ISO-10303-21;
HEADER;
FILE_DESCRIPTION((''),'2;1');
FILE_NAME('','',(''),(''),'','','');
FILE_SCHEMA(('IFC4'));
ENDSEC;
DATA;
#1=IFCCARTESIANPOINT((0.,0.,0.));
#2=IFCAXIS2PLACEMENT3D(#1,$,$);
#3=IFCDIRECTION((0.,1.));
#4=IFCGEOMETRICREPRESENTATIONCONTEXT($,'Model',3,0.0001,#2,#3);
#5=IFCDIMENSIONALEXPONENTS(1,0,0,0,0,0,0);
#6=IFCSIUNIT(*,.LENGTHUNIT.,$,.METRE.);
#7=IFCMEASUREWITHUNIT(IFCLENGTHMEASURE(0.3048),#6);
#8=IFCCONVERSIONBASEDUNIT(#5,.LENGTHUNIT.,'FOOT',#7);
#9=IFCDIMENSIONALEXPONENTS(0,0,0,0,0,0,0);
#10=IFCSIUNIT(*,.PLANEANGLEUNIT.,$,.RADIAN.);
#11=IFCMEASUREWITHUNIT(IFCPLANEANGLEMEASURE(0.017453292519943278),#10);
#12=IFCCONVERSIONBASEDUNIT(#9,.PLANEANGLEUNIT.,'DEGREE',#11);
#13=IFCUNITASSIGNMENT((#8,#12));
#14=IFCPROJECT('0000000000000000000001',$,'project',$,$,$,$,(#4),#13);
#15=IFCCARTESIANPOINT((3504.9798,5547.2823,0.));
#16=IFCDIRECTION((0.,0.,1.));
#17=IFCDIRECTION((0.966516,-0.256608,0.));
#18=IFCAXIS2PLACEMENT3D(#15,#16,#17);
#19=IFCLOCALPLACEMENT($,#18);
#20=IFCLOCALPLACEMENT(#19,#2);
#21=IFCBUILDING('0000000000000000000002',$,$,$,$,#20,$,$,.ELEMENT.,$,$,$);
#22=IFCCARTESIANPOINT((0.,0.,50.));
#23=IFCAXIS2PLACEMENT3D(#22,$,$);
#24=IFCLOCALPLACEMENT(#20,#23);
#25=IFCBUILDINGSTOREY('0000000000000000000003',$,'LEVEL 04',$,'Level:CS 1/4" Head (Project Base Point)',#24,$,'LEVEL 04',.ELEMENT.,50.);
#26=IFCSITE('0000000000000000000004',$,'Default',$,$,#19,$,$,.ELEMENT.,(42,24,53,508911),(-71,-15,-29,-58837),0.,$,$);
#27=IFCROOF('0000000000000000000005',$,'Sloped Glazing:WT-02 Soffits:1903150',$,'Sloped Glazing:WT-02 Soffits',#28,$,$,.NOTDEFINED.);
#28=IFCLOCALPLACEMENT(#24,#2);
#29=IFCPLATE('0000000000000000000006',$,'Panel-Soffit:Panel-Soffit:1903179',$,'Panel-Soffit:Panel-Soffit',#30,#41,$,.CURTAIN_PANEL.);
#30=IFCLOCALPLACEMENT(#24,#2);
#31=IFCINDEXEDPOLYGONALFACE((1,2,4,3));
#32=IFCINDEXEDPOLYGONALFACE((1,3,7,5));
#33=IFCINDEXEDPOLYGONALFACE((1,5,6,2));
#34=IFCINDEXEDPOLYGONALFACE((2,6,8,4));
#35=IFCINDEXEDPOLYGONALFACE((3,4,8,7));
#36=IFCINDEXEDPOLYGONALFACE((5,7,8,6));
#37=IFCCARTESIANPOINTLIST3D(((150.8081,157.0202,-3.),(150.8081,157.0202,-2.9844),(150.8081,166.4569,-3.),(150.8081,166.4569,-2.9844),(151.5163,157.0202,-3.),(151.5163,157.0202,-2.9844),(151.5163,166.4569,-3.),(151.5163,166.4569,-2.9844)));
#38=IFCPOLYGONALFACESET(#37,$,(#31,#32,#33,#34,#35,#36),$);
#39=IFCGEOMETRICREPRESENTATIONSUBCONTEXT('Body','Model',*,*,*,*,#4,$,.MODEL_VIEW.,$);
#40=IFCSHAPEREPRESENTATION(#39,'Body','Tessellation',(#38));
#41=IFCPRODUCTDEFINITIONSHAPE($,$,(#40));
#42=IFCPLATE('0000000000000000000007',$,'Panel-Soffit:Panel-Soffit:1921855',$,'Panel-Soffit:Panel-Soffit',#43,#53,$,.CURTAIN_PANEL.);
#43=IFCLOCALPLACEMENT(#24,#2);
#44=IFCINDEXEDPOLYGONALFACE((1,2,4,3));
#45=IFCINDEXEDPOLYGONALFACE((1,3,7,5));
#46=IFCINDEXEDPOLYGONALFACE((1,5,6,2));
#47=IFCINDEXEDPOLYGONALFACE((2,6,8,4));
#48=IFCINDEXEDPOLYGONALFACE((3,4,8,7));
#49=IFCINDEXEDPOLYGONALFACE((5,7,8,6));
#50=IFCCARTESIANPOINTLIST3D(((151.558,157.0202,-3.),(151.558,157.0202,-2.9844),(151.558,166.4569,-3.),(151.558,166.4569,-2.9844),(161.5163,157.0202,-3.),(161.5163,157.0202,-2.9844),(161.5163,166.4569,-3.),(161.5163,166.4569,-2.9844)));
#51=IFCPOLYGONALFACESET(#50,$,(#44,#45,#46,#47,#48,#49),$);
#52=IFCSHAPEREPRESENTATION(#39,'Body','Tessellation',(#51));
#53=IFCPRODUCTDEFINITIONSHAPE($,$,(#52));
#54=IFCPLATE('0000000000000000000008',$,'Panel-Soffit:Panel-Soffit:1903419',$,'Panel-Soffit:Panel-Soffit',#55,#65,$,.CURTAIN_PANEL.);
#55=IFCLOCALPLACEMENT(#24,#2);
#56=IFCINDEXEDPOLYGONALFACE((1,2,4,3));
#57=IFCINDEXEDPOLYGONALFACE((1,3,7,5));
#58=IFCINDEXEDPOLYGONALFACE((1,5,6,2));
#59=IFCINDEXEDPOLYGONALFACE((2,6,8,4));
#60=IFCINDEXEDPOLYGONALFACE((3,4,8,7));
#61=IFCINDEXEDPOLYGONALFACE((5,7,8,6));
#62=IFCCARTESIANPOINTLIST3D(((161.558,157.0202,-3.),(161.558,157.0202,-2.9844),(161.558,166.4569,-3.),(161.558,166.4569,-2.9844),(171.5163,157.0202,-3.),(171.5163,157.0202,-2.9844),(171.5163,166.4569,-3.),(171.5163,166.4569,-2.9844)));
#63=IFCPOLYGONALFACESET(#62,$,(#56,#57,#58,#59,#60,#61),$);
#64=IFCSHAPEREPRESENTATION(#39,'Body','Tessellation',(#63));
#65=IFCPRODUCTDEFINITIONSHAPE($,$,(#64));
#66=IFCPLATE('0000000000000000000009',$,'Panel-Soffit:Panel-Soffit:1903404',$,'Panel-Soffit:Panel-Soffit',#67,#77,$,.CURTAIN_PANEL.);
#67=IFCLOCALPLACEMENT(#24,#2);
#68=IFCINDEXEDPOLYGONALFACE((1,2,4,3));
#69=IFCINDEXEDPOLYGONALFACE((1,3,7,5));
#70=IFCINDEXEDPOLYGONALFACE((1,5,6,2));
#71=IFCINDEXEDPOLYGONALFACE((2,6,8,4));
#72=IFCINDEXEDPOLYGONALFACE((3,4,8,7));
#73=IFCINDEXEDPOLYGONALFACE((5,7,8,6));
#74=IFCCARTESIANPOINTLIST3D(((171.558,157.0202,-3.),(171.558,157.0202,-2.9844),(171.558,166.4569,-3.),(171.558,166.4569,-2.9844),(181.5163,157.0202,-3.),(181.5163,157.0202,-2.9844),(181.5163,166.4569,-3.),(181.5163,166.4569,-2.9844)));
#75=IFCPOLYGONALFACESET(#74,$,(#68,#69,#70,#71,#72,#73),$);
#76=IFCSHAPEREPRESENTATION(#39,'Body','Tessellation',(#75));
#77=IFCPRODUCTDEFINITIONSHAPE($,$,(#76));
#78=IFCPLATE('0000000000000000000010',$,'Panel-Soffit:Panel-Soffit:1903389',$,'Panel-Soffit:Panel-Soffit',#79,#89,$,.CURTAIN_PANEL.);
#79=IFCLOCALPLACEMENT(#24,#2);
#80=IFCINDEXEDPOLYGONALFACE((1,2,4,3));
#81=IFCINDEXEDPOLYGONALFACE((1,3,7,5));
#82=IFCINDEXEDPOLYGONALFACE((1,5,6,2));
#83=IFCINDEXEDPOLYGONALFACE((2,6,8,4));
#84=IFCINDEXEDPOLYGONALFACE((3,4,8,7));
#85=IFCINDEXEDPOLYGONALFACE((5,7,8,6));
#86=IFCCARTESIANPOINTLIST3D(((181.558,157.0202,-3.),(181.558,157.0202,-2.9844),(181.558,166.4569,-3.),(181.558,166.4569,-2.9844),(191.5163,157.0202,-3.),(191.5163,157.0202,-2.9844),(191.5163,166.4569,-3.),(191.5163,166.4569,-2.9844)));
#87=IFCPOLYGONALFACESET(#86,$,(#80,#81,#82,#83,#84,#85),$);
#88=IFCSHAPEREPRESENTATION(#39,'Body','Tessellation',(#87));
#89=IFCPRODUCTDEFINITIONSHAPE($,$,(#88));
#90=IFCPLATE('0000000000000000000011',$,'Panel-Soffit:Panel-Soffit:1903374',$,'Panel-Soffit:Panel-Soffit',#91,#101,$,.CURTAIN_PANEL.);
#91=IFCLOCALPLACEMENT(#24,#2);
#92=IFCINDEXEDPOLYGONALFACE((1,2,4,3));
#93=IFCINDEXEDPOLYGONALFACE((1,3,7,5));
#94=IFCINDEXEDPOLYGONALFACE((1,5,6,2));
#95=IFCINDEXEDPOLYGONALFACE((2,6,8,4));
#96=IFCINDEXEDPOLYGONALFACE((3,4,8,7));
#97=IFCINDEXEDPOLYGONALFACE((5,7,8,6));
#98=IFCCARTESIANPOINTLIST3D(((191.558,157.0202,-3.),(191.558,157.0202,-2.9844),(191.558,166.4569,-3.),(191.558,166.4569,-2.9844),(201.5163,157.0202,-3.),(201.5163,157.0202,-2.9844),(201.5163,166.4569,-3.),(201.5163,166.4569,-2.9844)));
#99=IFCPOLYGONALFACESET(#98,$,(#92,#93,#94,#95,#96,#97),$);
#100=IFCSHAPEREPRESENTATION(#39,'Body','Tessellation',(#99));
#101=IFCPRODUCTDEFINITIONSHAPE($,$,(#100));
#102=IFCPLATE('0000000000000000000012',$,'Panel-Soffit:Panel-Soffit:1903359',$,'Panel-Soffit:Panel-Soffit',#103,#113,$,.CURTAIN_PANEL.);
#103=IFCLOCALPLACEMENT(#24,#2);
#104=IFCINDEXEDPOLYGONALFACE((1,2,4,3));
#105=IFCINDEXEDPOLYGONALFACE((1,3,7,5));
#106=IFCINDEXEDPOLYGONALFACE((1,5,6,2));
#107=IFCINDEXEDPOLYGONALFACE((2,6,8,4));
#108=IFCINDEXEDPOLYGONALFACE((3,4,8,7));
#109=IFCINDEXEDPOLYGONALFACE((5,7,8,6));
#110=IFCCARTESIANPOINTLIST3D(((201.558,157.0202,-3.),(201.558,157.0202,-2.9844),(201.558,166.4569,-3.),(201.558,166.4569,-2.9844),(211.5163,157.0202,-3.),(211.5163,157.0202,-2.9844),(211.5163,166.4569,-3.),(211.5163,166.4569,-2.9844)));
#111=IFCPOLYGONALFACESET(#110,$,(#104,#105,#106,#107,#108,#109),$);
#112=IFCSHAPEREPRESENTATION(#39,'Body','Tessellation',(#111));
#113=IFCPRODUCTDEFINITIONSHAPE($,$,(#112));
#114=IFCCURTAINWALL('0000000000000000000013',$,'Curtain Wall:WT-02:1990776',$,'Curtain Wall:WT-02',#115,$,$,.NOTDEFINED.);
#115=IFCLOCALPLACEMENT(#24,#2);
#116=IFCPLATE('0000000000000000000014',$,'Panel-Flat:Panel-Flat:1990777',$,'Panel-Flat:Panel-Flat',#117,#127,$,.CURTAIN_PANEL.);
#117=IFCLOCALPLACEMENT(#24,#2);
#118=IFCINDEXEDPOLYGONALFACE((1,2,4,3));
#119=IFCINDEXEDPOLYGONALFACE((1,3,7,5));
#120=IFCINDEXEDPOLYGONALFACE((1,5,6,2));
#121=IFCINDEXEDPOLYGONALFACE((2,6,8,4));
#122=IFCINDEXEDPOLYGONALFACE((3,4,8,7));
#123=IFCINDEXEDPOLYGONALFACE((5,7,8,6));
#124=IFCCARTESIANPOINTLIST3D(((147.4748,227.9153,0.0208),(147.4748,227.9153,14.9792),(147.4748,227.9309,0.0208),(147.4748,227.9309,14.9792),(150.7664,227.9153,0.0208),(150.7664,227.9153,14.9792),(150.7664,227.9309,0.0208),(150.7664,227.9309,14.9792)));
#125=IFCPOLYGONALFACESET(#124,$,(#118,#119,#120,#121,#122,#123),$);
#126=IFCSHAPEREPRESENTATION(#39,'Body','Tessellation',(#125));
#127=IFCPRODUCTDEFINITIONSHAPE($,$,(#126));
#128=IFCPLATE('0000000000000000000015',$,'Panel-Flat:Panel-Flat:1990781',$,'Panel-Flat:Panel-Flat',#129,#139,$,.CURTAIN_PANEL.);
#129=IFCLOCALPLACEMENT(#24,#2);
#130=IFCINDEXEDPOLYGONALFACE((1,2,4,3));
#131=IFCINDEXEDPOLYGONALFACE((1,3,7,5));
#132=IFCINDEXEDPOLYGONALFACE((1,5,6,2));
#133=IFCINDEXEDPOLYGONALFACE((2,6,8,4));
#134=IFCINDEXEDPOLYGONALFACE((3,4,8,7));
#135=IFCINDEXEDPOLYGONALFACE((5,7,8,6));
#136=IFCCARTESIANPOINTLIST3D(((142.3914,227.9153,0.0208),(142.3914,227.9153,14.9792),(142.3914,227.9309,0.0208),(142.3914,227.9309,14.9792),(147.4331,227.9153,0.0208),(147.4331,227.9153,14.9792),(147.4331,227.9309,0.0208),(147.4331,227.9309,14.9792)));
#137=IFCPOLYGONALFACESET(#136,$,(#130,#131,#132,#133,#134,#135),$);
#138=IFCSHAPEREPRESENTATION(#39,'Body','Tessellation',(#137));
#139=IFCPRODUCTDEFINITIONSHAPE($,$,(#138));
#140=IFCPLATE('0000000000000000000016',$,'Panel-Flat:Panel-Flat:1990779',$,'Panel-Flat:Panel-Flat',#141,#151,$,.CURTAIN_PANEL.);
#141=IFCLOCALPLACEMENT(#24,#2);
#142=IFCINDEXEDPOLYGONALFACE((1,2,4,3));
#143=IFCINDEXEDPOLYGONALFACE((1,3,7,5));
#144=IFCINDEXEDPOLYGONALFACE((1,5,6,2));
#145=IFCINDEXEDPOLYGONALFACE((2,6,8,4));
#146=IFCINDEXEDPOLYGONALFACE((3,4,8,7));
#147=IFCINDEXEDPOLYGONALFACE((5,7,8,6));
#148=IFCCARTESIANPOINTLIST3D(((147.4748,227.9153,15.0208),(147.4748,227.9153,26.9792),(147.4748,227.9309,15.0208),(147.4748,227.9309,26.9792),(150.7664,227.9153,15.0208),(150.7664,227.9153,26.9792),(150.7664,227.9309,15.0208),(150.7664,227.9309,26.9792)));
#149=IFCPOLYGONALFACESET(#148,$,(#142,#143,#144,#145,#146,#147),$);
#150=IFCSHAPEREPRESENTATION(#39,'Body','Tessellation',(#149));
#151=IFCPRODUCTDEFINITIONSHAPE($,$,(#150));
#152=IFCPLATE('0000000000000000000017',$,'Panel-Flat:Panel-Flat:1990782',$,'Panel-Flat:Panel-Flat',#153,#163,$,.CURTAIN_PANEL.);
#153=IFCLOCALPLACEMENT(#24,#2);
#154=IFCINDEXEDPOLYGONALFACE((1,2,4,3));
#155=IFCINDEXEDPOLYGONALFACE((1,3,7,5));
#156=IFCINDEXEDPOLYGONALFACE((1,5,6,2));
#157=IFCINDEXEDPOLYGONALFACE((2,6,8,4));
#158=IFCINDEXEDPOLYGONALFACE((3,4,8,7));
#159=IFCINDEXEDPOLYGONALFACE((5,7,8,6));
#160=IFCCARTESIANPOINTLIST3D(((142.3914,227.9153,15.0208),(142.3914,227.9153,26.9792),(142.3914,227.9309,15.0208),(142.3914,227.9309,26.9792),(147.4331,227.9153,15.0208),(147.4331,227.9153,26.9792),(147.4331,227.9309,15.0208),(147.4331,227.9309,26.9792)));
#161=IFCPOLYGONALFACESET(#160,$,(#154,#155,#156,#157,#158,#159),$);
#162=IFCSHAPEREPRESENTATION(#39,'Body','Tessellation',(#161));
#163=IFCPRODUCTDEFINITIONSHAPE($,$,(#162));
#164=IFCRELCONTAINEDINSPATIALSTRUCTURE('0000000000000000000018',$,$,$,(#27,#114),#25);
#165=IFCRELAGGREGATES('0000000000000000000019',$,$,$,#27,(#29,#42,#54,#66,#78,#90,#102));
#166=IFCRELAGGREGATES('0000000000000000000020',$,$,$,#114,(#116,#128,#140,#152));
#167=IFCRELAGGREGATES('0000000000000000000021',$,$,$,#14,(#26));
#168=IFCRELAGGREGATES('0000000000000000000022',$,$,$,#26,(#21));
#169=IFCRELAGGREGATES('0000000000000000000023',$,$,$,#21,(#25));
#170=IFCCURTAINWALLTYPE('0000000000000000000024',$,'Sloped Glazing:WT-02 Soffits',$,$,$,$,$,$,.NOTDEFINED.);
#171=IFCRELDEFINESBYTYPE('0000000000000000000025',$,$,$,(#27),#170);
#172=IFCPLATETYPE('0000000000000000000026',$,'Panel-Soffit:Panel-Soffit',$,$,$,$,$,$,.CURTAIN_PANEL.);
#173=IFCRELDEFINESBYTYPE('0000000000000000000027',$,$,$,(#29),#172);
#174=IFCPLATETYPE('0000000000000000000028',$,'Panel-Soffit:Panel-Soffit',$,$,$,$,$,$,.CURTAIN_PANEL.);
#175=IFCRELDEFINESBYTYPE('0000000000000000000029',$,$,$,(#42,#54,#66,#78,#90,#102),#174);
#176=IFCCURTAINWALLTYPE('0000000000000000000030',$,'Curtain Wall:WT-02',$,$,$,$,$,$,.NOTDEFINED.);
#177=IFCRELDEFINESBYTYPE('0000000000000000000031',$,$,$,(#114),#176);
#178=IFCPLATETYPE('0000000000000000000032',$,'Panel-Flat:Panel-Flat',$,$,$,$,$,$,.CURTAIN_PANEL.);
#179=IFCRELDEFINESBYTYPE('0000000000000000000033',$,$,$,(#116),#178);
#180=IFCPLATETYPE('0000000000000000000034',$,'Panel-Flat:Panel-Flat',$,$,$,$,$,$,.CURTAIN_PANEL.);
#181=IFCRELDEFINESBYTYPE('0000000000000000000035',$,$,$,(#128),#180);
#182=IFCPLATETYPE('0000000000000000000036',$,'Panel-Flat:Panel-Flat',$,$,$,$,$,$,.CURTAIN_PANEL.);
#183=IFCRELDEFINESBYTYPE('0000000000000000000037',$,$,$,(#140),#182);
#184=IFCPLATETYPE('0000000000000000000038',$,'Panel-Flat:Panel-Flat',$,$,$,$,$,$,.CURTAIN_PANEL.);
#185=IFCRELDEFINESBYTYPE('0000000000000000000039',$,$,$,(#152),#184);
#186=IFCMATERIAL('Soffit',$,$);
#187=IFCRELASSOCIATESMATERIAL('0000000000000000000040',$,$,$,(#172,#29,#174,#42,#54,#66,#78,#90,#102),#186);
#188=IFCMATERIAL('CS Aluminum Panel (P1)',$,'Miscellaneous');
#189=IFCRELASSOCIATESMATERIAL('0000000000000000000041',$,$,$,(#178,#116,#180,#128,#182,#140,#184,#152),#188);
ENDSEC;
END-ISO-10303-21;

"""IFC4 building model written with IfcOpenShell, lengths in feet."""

from ifc_helpers import new_model, entity, si_unit, converted_unit, direction, frame, origin, place, context, subcontext, project, spatial, indexed_curve, outline, extrude, source, transform, mapped, material, type_object, type_shapes, element, aggregate, save


model = new_model("IFC4")

# Units and contexts
model_context = context("Model", 3, precision=0.0001, world=origin(), true_north=direction((0.0, 1.0)))
body_context = subcontext(model_context, "Body", "Model", "MODEL_VIEW")
ifc_project = project(units=[converted_unit("LENGTHUNIT", "FOOT", entity("IfcLengthMeasure", 0.3048), si_unit("LENGTHUNIT", "METRE"), dimensions=[1, 0, 0, 0, 0, 0, 0]), converted_unit("PLANEANGLEUNIT", "DEGREE", entity("IfcPlaneAngleMeasure", 0.017453292519943278), si_unit("PLANEANGLEUNIT", "RADIAN"), dimensions=[0, 0, 0, 0, 0, 0, 0])], contexts=[model_context])

# Site, building, storey
site_placement = place(None, frame((3504.9798, 5547.2823, 0.0), z_axis=(0.0, 0.0, 1.0), x_axis=(0.966516, -0.256608, 0.0)))
site = spatial("IfcSite", under=ifc_project, at=site_placement, Name="Default", CompositionType="ELEMENT", RefLatitude=(42, 24, 53, 508911), RefLongitude=(-71, -15, -29, -58837), RefElevation=0.0)
building_placement = place(site_placement, origin())
building = spatial("IfcBuilding", under=site, at=building_placement, CompositionType="ELEMENT")
storey_placement = place(building_placement, frame((0.0, 0.0, 50.0)))
storey = spatial("IfcBuildingStorey", under=building, at=storey_placement, Name="LEVEL 04", ObjectType="Level:CS 1/4\" Head (Project Base Point)", LongName="LEVEL 04", CompositionType="ELEMENT", Elevation=50.0)

# Roof, plates
curtain_wall_type_1 = type_object("IfcCurtainWallType", Name="Sloped Glazing:WT-02 Soffits", PredefinedType="NOTDEFINED")
roof_placement = place(storey_placement, frame((0.0, 0.0, -50.0)))
roof = element("IfcRoof", 1, at=roof_placement, inside=storey, type_object=curtain_wall_type_1, Name="Sloped Glazing:WT-02 Soffits:1903150", ObjectType="Sloped Glazing:WT-02 Soffits", PredefinedType="NOTDEFINED")
ifc_material_1 = material(Name="Soffit")
plate_type_1 = type_object("IfcPlateType", Name="Panel-Soffit:Panel-Soffit", PredefinedType="CURTAIN_PANEL", material=ifc_material_1)
shared_shape_1 = source(origin(), body_context, "Body", "SweptSolid", [
    extrude(outline(indexed_curve([(-0.0078, -0.3541), (0.0078, -0.3541), (0.0078, 0.3541), (-0.0078, 0.3541), (-0.0078, -0.3541)], self_intersect=False)), frame((0.3541, 0.0078, 0.0), z_axis=(0.0, 0.0, 1.0), x_axis=(0.0, -1.0, 0.0)), (0.0, 0.0, 1.0), 9.4367),
])
type_shapes(plate_type_1, [shared_shape_1])
plate_1_placement = place(roof_placement, frame((150.8081, 157.0202, 47.0156), z_axis=(0.0, 1.0, 0.0), x_axis=(1.0, 0.0, 0.0)))
plate_1 = element("IfcPlate", 2, at=plate_1_placement, type_object=plate_type_1, material=ifc_material_1, Name="Panel-Soffit:Panel-Soffit:1903179", ObjectType="Panel-Soffit:Panel-Soffit", PredefinedType="CURTAIN_PANEL", context=body_context, shape_type="MappedRepresentation", body=[
    mapped(shared_shape_1, transform((0.0, 0.0, 0.0), scale=1.0)),
])
plate_type_2 = type_object("IfcPlateType", Name="Panel-Soffit:Panel-Soffit", PredefinedType="CURTAIN_PANEL", material=ifc_material_1)
shared_shape_2 = source(origin(), body_context, "Body", "SweptSolid", [
    extrude(outline(indexed_curve([(-0.0078, -4.9792), (0.0078, -4.9792), (0.0078, 4.9792), (-0.0078, 4.9792), (-0.0078, -4.9792)], self_intersect=False)), frame((4.9792, 0.0078, 0.0), z_axis=(0.0, 0.0, 1.0), x_axis=(0.0, -1.0, 0.0)), (0.0, 0.0, 1.0), 9.4367),
])
type_shapes(plate_type_2, [shared_shape_2])
plate_2_placement = place(roof_placement, frame((151.558, 157.0202, 47.0156), z_axis=(0.0, 1.0, 0.0), x_axis=(1.0, 0.0, 0.0)))
plate_2 = element("IfcPlate", 3, at=plate_2_placement, type_object=plate_type_2, material=ifc_material_1, Name="Panel-Soffit:Panel-Soffit:1921855", ObjectType="Panel-Soffit:Panel-Soffit", PredefinedType="CURTAIN_PANEL", context=body_context, shape_type="MappedRepresentation", body=[
    mapped(shared_shape_2, transform((0.0, 0.0, 0.0), scale=1.0)),
])
plate_3_placement = place(roof_placement, frame((161.558, 157.0202, 47.0156), z_axis=(0.0, 1.0, 0.0), x_axis=(1.0, 0.0, 0.0)))
plate_3 = element("IfcPlate", 4, at=plate_3_placement, type_object=plate_type_2, material=ifc_material_1, Name="Panel-Soffit:Panel-Soffit:1903419", ObjectType="Panel-Soffit:Panel-Soffit", PredefinedType="CURTAIN_PANEL", context=body_context, shape_type="MappedRepresentation", body=[
    mapped(shared_shape_2, transform((0.0, 0.0, 0.0), scale=1.0)),
])
plate_4_placement = place(roof_placement, frame((171.558, 157.0202, 47.0156), z_axis=(0.0, 1.0, 0.0), x_axis=(1.0, 0.0, 0.0)))
plate_4 = element("IfcPlate", 5, at=plate_4_placement, type_object=plate_type_2, material=ifc_material_1, Name="Panel-Soffit:Panel-Soffit:1903404", ObjectType="Panel-Soffit:Panel-Soffit", PredefinedType="CURTAIN_PANEL", context=body_context, shape_type="MappedRepresentation", body=[
    mapped(shared_shape_2, transform((0.0, 0.0, 0.0), scale=1.0)),
])
plate_5_placement = place(roof_placement, frame((181.558, 157.0202, 47.0156), z_axis=(0.0, 1.0, 0.0), x_axis=(1.0, 0.0, 0.0)))
plate_5 = element("IfcPlate", 6, at=plate_5_placement, type_object=plate_type_2, material=ifc_material_1, Name="Panel-Soffit:Panel-Soffit:1903389", ObjectType="Panel-Soffit:Panel-Soffit", PredefinedType="CURTAIN_PANEL", context=body_context, shape_type="MappedRepresentation", body=[
    mapped(shared_shape_2, transform((0.0, 0.0, 0.0), scale=1.0)),
])
plate_6_placement = place(roof_placement, frame((191.558, 157.0202, 47.0156), z_axis=(0.0, 1.0, 0.0), x_axis=(1.0, 0.0, 0.0)))
plate_6 = element("IfcPlate", 7, at=plate_6_placement, type_object=plate_type_2, material=ifc_material_1, Name="Panel-Soffit:Panel-Soffit:1903374", ObjectType="Panel-Soffit:Panel-Soffit", PredefinedType="CURTAIN_PANEL", context=body_context, shape_type="MappedRepresentation", body=[
    mapped(shared_shape_2, transform((0.0, 0.0, 0.0), scale=1.0)),
])
plate_7_placement = place(roof_placement, frame((201.558, 157.0202, 47.0156), z_axis=(0.0, 1.0, 0.0), x_axis=(1.0, 0.0, 0.0)))
plate_7 = element("IfcPlate", 8, at=plate_7_placement, type_object=plate_type_2, material=ifc_material_1, Name="Panel-Soffit:Panel-Soffit:1903359", ObjectType="Panel-Soffit:Panel-Soffit", PredefinedType="CURTAIN_PANEL", context=body_context, shape_type="MappedRepresentation", body=[
    mapped(shared_shape_2, transform((0.0, 0.0, 0.0), scale=1.0)),
])
aggregate(roof, [plate_1, plate_2, plate_3, plate_4, plate_5, plate_6, plate_7])

# Shared definitions
curtain_wall_type_2 = type_object("IfcCurtainWallType", Name="Curtain Wall:WT-02", PredefinedType="NOTDEFINED")

# Curtain wall, plates
curtain_wall_1_placement = place(storey_placement, frame((0.0, 0.0, -50.0)))
curtain_wall_1 = element("IfcCurtainWall", 9, at=curtain_wall_1_placement, inside=storey, type_object=curtain_wall_type_2, Name="Curtain Wall:WT-02:1990776", ObjectType="Curtain Wall:WT-02", PredefinedType="NOTDEFINED")
ifc_material_2 = material(Name="CS Aluminum Panel (P1)", Category="Miscellaneous")
plate_type_3 = type_object("IfcPlateType", Name="Panel-Flat:Panel-Flat", PredefinedType="CURTAIN_PANEL", material=ifc_material_2)
shared_shape_3 = source(origin(), body_context, "Body", "SweptSolid", [
    extrude(outline(indexed_curve([(-0.0078, -1.6458), (0.0078, -1.6458), (0.0078, 1.6458), (-0.0078, 1.6458), (-0.0078, -1.6458)], self_intersect=False)), frame((1.6458, 0.0078, 0.0), z_axis=(0.0, 0.0, 1.0), x_axis=(0.0, -1.0, 0.0)), (0.0, 0.0, 1.0), 14.9583),
])
type_shapes(plate_type_3, [shared_shape_3])
plate_8_placement = place(curtain_wall_1_placement, frame((150.7664, 227.9309, 50.0208), z_axis=(0.0, 0.0, 1.0), x_axis=(-1.0, 0.0, 0.0)))
plate_8 = element("IfcPlate", 10, at=plate_8_placement, type_object=plate_type_3, material=ifc_material_2, Name="Panel-Flat:Panel-Flat:1990777", ObjectType="Panel-Flat:Panel-Flat", PredefinedType="CURTAIN_PANEL", context=body_context, shape_type="MappedRepresentation", body=[
    mapped(shared_shape_3, transform((0.0, 0.0, 0.0), scale=1.0)),
])
plate_type_4 = type_object("IfcPlateType", Name="Panel-Flat:Panel-Flat", PredefinedType="CURTAIN_PANEL", material=ifc_material_2)
shared_shape_4 = source(origin(), body_context, "Body", "SweptSolid", [
    extrude(outline(indexed_curve([(-0.0078, -2.5208), (0.0078, -2.5208), (0.0078, 2.5208), (-0.0078, 2.5208), (-0.0078, -2.5208)], self_intersect=False)), frame((2.5208, 0.0078, 0.0), z_axis=(0.0, 0.0, 1.0), x_axis=(0.0, -1.0, 0.0)), (0.0, 0.0, 1.0), 14.9583),
])
type_shapes(plate_type_4, [shared_shape_4])
plate_9_placement = place(curtain_wall_1_placement, frame((147.4331, 227.9309, 50.0208), z_axis=(0.0, 0.0, 1.0), x_axis=(-1.0, 0.0, 0.0)))
plate_9 = element("IfcPlate", 11, at=plate_9_placement, type_object=plate_type_4, material=ifc_material_2, Name="Panel-Flat:Panel-Flat:1990781", ObjectType="Panel-Flat:Panel-Flat", PredefinedType="CURTAIN_PANEL", context=body_context, shape_type="MappedRepresentation", body=[
    mapped(shared_shape_4, transform((0.0, 0.0, 0.0), scale=1.0)),
])
plate_type_5 = type_object("IfcPlateType", Name="Panel-Flat:Panel-Flat", PredefinedType="CURTAIN_PANEL", material=ifc_material_2)
shared_shape_5 = source(origin(), body_context, "Body", "SweptSolid", [
    extrude(outline(indexed_curve([(-0.0078, -1.6458), (0.0078, -1.6458), (0.0078, 1.6458), (-0.0078, 1.6458), (-0.0078, -1.6458)], self_intersect=False)), frame((1.6458, 0.0078, 0.0), z_axis=(0.0, 0.0, 1.0), x_axis=(0.0, -1.0, 0.0)), (0.0, 0.0, 1.0), 11.9583),
])
type_shapes(plate_type_5, [shared_shape_5])
plate_10_placement = place(curtain_wall_1_placement, frame((150.7664, 227.9309, 65.0208), z_axis=(0.0, 0.0, 1.0), x_axis=(-1.0, 0.0, 0.0)))
plate_10 = element("IfcPlate", 12, at=plate_10_placement, type_object=plate_type_5, material=ifc_material_2, Name="Panel-Flat:Panel-Flat:1990779", ObjectType="Panel-Flat:Panel-Flat", PredefinedType="CURTAIN_PANEL", context=body_context, shape_type="MappedRepresentation", body=[
    mapped(shared_shape_5, transform((0.0, 0.0, 0.0), scale=1.0)),
])
plate_type_6 = type_object("IfcPlateType", Name="Panel-Flat:Panel-Flat", PredefinedType="CURTAIN_PANEL", material=ifc_material_2)
shared_shape_6 = source(origin(), body_context, "Body", "SweptSolid", [
    extrude(outline(indexed_curve([(-0.0078, -2.5208), (0.0078, -2.5208), (0.0078, 2.5208), (-0.0078, 2.5208), (-0.0078, -2.5208)], self_intersect=False)), frame((2.5208, 0.0078, 0.0), z_axis=(0.0, 0.0, 1.0), x_axis=(0.0, -1.0, 0.0)), (0.0, 0.0, 1.0), 11.9583),
])
type_shapes(plate_type_6, [shared_shape_6])
plate_11_placement = place(curtain_wall_1_placement, frame((147.4331, 227.9309, 65.0208), z_axis=(0.0, 0.0, 1.0), x_axis=(-1.0, 0.0, 0.0)))
plate_11 = element("IfcPlate", 13, at=plate_11_placement, type_object=plate_type_6, material=ifc_material_2, Name="Panel-Flat:Panel-Flat:1990782", ObjectType="Panel-Flat:Panel-Flat", PredefinedType="CURTAIN_PANEL", context=body_context, shape_type="MappedRepresentation", body=[
    mapped(shared_shape_6, transform((0.0, 0.0, 0.0), scale=1.0)),
])
aggregate(curtain_wall_1, [plate_8, plate_9, plate_10, plate_11])

save(model, "model.ifc")
